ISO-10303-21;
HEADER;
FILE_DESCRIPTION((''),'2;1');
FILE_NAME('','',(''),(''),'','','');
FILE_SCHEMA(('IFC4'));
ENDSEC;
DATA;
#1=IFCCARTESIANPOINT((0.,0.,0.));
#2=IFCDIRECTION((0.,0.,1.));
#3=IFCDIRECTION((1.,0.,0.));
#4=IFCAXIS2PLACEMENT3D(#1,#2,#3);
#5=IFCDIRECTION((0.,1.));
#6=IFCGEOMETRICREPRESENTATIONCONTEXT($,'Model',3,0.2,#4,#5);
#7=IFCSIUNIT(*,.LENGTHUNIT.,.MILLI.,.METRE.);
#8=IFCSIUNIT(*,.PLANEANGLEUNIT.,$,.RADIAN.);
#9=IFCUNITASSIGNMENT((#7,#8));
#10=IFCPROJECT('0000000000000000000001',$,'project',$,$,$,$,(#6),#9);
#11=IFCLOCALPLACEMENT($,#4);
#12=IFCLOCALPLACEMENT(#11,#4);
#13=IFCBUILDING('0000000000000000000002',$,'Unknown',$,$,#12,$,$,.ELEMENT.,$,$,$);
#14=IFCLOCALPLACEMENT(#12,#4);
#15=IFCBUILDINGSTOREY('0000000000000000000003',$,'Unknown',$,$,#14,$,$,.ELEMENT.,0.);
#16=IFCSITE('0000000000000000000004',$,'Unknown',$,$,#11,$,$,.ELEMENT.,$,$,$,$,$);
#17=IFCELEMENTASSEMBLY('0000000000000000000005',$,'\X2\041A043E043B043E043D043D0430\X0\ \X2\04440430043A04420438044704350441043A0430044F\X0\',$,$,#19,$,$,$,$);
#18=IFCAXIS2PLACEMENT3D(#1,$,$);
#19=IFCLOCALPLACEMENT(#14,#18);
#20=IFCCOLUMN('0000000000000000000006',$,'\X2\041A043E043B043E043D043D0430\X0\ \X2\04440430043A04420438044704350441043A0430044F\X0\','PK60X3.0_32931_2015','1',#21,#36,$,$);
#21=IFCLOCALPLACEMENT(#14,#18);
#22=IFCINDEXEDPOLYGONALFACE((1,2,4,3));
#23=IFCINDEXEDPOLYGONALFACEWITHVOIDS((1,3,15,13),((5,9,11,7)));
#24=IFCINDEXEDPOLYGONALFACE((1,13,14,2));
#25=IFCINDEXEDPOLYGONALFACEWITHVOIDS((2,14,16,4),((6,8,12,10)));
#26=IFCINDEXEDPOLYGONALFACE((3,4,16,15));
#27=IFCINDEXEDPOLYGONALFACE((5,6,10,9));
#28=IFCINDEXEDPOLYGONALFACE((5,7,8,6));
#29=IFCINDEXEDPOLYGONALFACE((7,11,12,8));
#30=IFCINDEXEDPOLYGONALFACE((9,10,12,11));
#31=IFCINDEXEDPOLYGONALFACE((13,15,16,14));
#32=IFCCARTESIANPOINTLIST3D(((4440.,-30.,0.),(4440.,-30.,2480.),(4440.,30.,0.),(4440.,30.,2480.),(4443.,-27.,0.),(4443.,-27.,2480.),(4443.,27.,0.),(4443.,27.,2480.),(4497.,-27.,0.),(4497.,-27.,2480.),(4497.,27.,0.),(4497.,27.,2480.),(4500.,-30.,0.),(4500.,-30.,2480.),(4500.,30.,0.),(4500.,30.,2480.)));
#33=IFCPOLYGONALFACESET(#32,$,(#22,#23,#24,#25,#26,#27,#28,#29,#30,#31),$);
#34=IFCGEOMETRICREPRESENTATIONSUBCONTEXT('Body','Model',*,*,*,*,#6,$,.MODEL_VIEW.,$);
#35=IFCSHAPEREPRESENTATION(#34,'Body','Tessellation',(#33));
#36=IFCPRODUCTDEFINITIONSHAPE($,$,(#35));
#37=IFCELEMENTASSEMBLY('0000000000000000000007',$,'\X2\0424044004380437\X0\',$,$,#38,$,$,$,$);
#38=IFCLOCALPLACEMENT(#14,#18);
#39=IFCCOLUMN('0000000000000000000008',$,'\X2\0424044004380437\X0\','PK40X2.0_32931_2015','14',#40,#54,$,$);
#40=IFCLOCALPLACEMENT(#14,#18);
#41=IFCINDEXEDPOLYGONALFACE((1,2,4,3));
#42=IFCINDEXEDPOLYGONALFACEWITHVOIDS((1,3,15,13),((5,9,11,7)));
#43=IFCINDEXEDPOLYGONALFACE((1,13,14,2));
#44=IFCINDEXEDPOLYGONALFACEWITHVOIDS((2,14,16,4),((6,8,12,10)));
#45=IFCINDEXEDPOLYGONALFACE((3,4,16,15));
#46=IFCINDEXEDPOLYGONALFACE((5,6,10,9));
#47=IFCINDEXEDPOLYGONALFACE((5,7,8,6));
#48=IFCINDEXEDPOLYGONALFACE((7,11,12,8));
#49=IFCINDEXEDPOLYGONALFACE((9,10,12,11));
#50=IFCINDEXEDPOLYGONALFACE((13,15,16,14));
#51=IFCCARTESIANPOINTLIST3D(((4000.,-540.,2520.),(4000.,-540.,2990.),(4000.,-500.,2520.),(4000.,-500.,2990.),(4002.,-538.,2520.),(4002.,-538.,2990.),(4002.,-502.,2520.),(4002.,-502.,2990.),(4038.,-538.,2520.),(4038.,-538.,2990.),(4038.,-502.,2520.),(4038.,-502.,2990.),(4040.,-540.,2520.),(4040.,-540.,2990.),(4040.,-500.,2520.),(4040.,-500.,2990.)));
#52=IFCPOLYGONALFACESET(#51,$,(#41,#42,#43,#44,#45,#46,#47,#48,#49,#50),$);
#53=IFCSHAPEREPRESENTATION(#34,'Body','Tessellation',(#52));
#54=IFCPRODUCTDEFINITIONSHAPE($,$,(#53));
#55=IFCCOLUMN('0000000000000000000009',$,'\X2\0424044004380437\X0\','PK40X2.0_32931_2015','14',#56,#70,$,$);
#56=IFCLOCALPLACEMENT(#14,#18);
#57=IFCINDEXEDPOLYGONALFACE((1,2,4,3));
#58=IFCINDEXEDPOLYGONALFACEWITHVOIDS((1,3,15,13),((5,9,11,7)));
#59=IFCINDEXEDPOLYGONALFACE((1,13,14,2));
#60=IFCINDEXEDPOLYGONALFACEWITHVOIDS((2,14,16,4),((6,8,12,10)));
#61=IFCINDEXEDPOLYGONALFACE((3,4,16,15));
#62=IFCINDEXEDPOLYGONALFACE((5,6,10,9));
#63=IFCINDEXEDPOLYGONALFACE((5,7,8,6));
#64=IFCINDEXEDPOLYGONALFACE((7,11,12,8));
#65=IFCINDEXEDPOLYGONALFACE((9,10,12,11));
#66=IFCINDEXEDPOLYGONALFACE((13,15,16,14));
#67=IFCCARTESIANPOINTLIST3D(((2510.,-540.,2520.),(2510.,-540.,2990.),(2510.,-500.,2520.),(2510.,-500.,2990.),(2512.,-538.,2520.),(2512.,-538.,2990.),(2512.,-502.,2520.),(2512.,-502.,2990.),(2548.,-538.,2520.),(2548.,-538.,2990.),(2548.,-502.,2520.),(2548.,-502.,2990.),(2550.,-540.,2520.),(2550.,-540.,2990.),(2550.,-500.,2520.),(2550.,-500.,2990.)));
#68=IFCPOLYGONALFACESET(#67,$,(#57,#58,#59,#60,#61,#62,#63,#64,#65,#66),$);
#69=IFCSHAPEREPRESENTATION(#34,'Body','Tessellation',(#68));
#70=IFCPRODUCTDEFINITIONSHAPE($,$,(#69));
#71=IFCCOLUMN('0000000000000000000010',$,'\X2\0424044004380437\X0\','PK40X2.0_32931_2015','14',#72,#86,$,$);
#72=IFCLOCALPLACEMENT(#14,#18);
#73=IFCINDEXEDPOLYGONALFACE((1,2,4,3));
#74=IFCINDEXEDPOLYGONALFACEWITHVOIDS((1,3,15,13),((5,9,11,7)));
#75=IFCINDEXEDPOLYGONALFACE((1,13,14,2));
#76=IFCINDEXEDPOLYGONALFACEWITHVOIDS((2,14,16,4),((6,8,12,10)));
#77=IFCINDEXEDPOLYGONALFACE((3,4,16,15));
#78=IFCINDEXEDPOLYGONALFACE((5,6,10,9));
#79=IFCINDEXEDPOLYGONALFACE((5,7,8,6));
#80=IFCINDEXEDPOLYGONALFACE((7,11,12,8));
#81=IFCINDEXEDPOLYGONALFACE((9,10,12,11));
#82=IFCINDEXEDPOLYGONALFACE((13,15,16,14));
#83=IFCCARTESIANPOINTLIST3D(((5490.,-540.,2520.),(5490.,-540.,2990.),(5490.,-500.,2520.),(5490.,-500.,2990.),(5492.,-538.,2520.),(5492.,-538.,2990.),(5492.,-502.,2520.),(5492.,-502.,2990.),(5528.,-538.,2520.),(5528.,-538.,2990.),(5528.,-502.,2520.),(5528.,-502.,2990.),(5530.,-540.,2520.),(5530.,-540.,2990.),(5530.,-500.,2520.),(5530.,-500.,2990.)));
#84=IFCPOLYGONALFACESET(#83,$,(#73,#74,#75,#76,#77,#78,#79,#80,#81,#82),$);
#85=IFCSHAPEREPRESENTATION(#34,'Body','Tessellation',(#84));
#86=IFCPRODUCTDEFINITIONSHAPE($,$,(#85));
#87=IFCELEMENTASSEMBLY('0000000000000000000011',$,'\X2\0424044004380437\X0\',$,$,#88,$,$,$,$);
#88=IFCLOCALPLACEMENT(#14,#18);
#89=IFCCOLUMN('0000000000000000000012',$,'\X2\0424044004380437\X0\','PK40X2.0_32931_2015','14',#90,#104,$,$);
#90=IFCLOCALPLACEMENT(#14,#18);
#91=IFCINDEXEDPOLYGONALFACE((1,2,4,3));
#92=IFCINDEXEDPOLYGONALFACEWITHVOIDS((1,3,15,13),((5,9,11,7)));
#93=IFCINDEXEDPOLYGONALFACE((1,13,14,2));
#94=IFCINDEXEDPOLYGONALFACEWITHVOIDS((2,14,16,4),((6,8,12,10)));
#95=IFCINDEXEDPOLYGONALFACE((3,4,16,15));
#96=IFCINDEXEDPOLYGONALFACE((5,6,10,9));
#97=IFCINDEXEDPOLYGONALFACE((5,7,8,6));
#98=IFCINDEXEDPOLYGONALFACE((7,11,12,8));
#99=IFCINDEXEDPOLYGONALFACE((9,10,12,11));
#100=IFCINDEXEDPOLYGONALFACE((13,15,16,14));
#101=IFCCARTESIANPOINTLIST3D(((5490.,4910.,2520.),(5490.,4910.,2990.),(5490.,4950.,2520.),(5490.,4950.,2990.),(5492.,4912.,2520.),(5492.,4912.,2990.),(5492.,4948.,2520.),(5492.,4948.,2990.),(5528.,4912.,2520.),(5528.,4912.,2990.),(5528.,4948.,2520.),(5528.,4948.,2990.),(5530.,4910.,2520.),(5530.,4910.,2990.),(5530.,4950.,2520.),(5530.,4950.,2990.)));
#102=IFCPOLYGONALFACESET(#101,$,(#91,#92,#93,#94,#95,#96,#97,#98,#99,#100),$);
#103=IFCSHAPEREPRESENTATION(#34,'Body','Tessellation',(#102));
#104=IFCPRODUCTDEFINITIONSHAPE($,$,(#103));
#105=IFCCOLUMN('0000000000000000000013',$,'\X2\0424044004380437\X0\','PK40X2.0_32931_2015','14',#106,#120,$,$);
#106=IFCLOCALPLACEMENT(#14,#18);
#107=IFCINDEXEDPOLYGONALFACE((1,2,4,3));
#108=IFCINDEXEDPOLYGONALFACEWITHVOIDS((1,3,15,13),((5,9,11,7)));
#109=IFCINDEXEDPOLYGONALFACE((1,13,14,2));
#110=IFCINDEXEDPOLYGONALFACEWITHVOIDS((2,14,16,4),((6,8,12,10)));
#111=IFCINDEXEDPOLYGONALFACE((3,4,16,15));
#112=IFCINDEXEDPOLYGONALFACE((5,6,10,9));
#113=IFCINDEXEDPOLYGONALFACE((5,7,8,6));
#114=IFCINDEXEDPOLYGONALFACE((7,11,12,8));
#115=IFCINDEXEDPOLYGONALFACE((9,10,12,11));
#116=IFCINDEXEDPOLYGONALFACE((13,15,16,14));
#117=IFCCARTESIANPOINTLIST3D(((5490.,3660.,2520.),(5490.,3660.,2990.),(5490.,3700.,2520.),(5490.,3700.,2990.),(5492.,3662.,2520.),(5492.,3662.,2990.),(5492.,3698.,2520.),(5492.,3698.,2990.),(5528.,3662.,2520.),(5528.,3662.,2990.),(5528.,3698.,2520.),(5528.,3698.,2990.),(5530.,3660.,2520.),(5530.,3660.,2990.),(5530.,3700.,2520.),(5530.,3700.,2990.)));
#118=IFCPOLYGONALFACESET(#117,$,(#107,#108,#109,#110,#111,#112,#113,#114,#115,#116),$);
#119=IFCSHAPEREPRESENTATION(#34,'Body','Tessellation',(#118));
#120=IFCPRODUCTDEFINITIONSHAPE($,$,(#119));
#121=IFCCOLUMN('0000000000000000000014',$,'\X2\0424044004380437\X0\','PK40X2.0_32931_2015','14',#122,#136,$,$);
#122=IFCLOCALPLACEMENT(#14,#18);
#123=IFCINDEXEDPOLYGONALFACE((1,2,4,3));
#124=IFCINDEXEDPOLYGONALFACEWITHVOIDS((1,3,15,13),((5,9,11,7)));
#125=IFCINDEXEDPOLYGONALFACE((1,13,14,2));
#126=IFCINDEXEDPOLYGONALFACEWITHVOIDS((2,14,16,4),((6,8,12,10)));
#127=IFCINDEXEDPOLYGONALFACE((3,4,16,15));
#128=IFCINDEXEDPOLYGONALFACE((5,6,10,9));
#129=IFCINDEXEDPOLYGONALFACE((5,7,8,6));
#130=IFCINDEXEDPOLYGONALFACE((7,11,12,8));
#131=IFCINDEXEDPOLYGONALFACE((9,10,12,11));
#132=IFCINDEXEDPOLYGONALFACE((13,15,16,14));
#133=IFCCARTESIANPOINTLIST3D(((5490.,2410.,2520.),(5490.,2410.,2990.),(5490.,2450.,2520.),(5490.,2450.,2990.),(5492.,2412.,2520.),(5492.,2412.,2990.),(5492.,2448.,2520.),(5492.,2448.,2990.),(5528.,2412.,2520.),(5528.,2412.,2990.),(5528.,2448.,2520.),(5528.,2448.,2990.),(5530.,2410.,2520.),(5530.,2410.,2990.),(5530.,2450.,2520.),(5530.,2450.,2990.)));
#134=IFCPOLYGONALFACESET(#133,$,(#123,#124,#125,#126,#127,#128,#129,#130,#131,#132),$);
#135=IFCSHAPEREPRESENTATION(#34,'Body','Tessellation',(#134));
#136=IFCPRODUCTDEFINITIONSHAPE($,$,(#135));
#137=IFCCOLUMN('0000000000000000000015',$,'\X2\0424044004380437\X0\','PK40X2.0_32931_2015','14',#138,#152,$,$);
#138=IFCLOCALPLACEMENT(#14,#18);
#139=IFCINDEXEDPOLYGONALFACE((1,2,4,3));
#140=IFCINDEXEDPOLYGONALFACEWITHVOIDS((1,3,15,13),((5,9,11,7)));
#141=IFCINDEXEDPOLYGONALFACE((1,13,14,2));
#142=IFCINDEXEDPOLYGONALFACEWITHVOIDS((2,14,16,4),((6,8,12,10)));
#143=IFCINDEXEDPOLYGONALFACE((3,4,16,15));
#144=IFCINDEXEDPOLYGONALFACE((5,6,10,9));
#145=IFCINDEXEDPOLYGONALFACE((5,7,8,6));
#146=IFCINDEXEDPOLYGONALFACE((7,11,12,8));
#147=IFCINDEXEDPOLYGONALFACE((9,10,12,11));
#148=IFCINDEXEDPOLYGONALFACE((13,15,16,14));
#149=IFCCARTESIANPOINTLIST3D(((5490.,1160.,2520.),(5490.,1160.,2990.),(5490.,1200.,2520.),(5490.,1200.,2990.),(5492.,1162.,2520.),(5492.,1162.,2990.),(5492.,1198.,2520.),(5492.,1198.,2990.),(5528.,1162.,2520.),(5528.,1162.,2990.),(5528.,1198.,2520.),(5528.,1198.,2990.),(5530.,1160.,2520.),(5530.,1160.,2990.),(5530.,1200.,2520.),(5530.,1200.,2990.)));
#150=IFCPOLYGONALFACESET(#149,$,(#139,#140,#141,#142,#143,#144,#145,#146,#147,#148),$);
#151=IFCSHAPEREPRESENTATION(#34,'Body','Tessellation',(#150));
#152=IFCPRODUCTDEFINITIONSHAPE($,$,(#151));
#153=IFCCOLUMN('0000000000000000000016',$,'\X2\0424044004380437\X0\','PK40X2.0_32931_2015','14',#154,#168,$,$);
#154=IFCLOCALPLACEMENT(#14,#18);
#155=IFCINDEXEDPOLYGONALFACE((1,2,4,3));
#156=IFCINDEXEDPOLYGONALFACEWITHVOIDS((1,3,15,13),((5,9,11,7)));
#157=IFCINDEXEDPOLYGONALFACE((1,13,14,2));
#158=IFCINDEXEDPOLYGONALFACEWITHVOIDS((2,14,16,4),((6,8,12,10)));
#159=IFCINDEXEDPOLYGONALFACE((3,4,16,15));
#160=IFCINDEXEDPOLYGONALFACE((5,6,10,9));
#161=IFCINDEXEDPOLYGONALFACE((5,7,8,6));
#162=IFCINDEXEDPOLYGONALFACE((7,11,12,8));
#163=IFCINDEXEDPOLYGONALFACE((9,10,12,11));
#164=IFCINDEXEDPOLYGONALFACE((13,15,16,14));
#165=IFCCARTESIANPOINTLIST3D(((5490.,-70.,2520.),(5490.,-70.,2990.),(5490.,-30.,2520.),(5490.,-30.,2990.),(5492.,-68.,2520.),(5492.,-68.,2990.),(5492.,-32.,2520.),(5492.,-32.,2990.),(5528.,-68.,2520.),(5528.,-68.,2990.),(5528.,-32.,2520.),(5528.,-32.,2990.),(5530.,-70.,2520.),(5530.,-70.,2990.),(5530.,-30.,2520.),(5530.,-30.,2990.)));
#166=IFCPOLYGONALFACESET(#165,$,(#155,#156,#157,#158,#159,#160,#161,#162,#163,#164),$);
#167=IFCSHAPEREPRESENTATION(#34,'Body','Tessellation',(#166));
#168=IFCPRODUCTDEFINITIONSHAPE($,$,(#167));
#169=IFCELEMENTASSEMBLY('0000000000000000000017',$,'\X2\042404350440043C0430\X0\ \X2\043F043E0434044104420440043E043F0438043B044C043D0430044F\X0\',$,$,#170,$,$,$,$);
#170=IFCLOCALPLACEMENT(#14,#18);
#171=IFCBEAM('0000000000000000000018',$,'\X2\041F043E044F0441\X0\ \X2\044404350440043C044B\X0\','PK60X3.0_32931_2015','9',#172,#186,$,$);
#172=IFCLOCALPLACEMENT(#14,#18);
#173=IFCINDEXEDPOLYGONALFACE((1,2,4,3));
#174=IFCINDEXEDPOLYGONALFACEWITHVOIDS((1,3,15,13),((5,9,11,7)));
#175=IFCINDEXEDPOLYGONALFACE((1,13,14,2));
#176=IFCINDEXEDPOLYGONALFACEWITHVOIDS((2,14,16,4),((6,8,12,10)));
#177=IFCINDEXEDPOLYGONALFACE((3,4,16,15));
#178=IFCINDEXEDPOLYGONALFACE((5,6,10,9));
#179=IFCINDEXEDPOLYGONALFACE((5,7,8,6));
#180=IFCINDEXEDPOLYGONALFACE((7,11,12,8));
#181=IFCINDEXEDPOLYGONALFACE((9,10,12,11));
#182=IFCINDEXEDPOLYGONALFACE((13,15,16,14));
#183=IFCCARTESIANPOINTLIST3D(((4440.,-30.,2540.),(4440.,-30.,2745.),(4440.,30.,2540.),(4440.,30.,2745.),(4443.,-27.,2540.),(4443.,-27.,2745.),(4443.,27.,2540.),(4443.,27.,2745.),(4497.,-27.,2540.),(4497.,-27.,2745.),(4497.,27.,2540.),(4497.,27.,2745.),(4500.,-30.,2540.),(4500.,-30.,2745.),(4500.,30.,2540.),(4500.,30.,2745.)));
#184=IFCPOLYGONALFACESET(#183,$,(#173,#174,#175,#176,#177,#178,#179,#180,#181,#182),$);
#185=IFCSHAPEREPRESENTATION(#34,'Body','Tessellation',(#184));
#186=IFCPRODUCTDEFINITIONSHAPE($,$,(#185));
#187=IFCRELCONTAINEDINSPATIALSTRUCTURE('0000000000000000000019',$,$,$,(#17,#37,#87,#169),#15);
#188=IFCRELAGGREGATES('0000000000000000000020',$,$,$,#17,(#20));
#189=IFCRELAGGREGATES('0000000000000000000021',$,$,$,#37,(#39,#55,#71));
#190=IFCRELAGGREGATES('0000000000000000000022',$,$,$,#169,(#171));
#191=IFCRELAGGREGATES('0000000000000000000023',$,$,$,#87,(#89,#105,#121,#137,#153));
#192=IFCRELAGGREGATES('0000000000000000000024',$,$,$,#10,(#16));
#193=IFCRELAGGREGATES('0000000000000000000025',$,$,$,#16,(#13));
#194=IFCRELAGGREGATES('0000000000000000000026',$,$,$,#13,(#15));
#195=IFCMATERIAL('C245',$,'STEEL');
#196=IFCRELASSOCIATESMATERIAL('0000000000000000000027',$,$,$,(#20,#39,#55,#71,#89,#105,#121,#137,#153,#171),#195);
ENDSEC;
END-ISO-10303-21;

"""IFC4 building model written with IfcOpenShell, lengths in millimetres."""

from ifc_helpers import new_model, si_unit, direction, frame, origin_with_axes, place, context, subcontext, project, spatial, line, indexed_curve, outline, extrude, material, element, aggregate, save


model = new_model("IFC4")

# Units and contexts
model_context = context("Model", 3, precision=0.2, world=origin_with_axes(), true_north=direction((0.0, 1.0)))
body_context = subcontext(model_context, "Body", "Model", "MODEL_VIEW")
ifc_project = project(units=[si_unit("LENGTHUNIT", "METRE", prefix="MILLI"), si_unit("PLANEANGLEUNIT", "RADIAN")], contexts=[model_context])

# Site, building, storey
site_placement = place(None, origin_with_axes())
site = spatial("IfcSite", under=ifc_project, at=site_placement, Name="Unknown", CompositionType="ELEMENT")
building_placement = place(site_placement, origin_with_axes())
building = spatial("IfcBuilding", under=site, at=building_placement, Name="Unknown", CompositionType="ELEMENT")
storey_placement = place(building_placement, origin_with_axes())
storey = spatial("IfcBuildingStorey", under=building, at=storey_placement, Name="Unknown", CompositionType="ELEMENT", Elevation=0.0)

# Element assembly, column
assembly_1_placement = place(storey_placement, frame((4470.0, 0.0, 0.0), z_axis=(-1.0, 0.0, 0.0), x_axis=(0.0, 0.0, 1.0)))
assembly_1 = element("IfcElementAssembly", 1, at=assembly_1_placement, inside=storey, Name="Колонна фактическая")
ifc_material = material(Name="C245", Category="STEEL")
column_1_placement = place(assembly_1_placement, origin_with_axes())
column_1 = element("IfcColumn", 2, at=column_1_placement, material=ifc_material, Name="Колонна фактическая", Description="PK60X3.0_32931_2015", ObjectType="1", context=body_context, shape_type="SolidModel", body=[
    extrude(outline(indexed_curve([(-30.0, -30.0), (30.0, -30.0), (30.0, 30.0), (-30.0, 30.0)], segments=[line(1, 2, 3, 4, 1)]), holes=[indexed_curve([(-27.0, -27.0), (-27.0, 27.0), (27.0, 27.0), (27.0, -27.0)], segments=[line(1, 2, 3, 4, 1)])]), frame((0.0, 0.0, 0.0), z_axis=(-1.0, 0.0, 0.0), x_axis=(0.0, 0.0, 1.0)), (0.0, 0.0, -1.0), 2480.0),
])
aggregate(assembly_1, [column_1])

# Element assemblies, columns
assembly_2_placement = place(storey_placement, frame((-470.0, -520.0, 3010.0), z_axis=(0.0, -1.0, 0.0), x_axis=(1.0, 0.0, 0.0)))
assembly_2 = element("IfcElementAssembly", 3, at=assembly_2_placement, inside=storey, Name="Фриз")
column_2_placement = place(assembly_2_placement, frame((4490.0, -490.0, 0.0), z_axis=(0.0, 0.0, -1.0), x_axis=(0.0, 1.0, 0.0)))
column_2 = element("IfcColumn", 4, at=column_2_placement, material=ifc_material, Name="Фриз", Description="PK40X2.0_32931_2015", ObjectType="14", context=body_context, shape_type="SolidModel", body=[
    extrude(outline(indexed_curve([(-20.0, -20.0), (20.0, -20.0), (20.0, 20.0), (-20.0, 20.0)], segments=[line(1, 2, 3, 4, 1)]), holes=[indexed_curve([(-18.0, -18.0), (-18.0, 18.0), (18.0, 18.0), (18.0, -18.0)], segments=[line(1, 2, 3, 4, 1)])]), frame((0.0, 0.0, 0.0), z_axis=(-1.0, 0.0, 0.0), x_axis=(0.0, 0.0, 1.0)), (0.0, 0.0, -1.0), 470.0),
])
column_3_placement = place(assembly_2_placement, frame((3000.0, -490.0, 0.0), z_axis=(0.0, 0.0, -1.0), x_axis=(0.0, 1.0, 0.0)))
column_3 = element("IfcColumn", 5, at=column_3_placement, material=ifc_material, Name="Фриз", Description="PK40X2.0_32931_2015", ObjectType="14", context=body_context, shape_type="SolidModel", body=[
    extrude(outline(indexed_curve([(-20.0, -20.0), (20.0, -20.0), (20.0, 20.0), (-20.0, 20.0)], segments=[line(1, 2, 3, 4, 1)]), holes=[indexed_curve([(-18.0, -18.0), (-18.0, 18.0), (18.0, 18.0), (18.0, -18.0)], segments=[line(1, 2, 3, 4, 1)])]), frame((0.0, 0.0, 0.0), z_axis=(-1.0, 0.0, 0.0), x_axis=(0.0, 0.0, 1.0)), (0.0, 0.0, -1.0), 470.0),
])
column_4_placement = place(assembly_2_placement, frame((5980.0, -490.0, 0.0), z_axis=(0.0, 0.0, 1.0), x_axis=(0.0, 1.0, 0.0)))
column_4 = element("IfcColumn", 6, at=column_4_placement, material=ifc_material, Name="Фриз", Description="PK40X2.0_32931_2015", ObjectType="14", context=body_context, shape_type="SolidModel", body=[
    extrude(outline(indexed_curve([(-20.0, -20.0), (20.0, -20.0), (20.0, 20.0), (-20.0, 20.0)], segments=[line(1, 2, 3, 4, 1)]), holes=[indexed_curve([(-18.0, -18.0), (-18.0, 18.0), (18.0, 18.0), (18.0, -18.0)], segments=[line(1, 2, 3, 4, 1)])]), frame((0.0, 0.0, 0.0), z_axis=(-1.0, 0.0, 0.0), x_axis=(0.0, 0.0, 1.0)), (0.0, 0.0, -1.0), 470.0),
])
aggregate(assembly_2, [column_2, column_3, column_4])
assembly_3_placement = place(storey_placement, frame((5510.0, -500.0, 3010.0), z_axis=(1.0, 0.0, 0.0), x_axis=(0.0, 1.0, 0.0)))
assembly_3 = element("IfcElementAssembly", 7, at=assembly_3_placement, inside=storey, Name="Фриз")
column_5_placement = place(assembly_3_placement, frame((5430.0, -490.0, 0.0), z_axis=(-1.0, 0.0, 0.0), x_axis=(0.0, 1.0, 0.0)))
column_5 = element("IfcColumn", 8, at=column_5_placement, material=ifc_material, Name="Фриз", Description="PK40X2.0_32931_2015", ObjectType="14", context=body_context, shape_type="SolidModel", body=[
    extrude(outline(indexed_curve([(-20.0, -20.0), (20.0, -20.0), (20.0, 20.0), (-20.0, 20.0)], segments=[line(1, 2, 3, 4, 1)]), holes=[indexed_curve([(-18.0, -18.0), (-18.0, 18.0), (18.0, 18.0), (18.0, -18.0)], segments=[line(1, 2, 3, 4, 1)])]), frame((0.0, 0.0, 0.0), z_axis=(-1.0, 0.0, 0.0), x_axis=(0.0, 0.0, 1.0)), (0.0, 0.0, -1.0), 470.0),
])
column_6_placement = place(assembly_3_placement, frame((4180.0, -490.0, 0.0), z_axis=(-1.0, 0.0, 0.0), x_axis=(0.0, 1.0, 0.0)))
column_6 = element("IfcColumn", 9, at=column_6_placement, material=ifc_material, Name="Фриз", Description="PK40X2.0_32931_2015", ObjectType="14", context=body_context, shape_type="SolidModel", body=[
    extrude(outline(indexed_curve([(-20.0, -20.0), (20.0, -20.0), (20.0, 20.0), (-20.0, 20.0)], segments=[line(1, 2, 3, 4, 1)]), holes=[indexed_curve([(-18.0, -18.0), (-18.0, 18.0), (18.0, 18.0), (18.0, -18.0)], segments=[line(1, 2, 3, 4, 1)])]), frame((0.0, 0.0, 0.0), z_axis=(-1.0, 0.0, 0.0), x_axis=(0.0, 0.0, 1.0)), (0.0, 0.0, -1.0), 470.0),
])
column_7_placement = place(assembly_3_placement, frame((2930.0, -490.0, 0.0), z_axis=(-1.0, 0.0, 0.0), x_axis=(0.0, 1.0, 0.0)))
column_7 = element("IfcColumn", 10, at=column_7_placement, material=ifc_material, Name="Фриз", Description="PK40X2.0_32931_2015", ObjectType="14", context=body_context, shape_type="SolidModel", body=[
    extrude(outline(indexed_curve([(-20.0, -20.0), (20.0, -20.0), (20.0, 20.0), (-20.0, 20.0)], segments=[line(1, 2, 3, 4, 1)]), holes=[indexed_curve([(-18.0, -18.0), (-18.0, 18.0), (18.0, 18.0), (18.0, -18.0)], segments=[line(1, 2, 3, 4, 1)])]), frame((0.0, 0.0, 0.0), z_axis=(-1.0, 0.0, 0.0), x_axis=(0.0, 0.0, 1.0)), (0.0, 0.0, -1.0), 470.0),
])
column_8_placement = place(assembly_3_placement, frame((1680.0, -490.0, 0.0), z_axis=(-1.0, 0.0, 0.0), x_axis=(0.0, 1.0, 0.0)))
column_8 = element("IfcColumn", 11, at=column_8_placement, material=ifc_material, Name="Фриз", Description="PK40X2.0_32931_2015", ObjectType="14", context=body_context, shape_type="SolidModel", body=[
    extrude(outline(indexed_curve([(-20.0, -20.0), (20.0, -20.0), (20.0, 20.0), (-20.0, 20.0)], segments=[line(1, 2, 3, 4, 1)]), holes=[indexed_curve([(-18.0, -18.0), (-18.0, 18.0), (18.0, 18.0), (18.0, -18.0)], segments=[line(1, 2, 3, 4, 1)])]), frame((0.0, 0.0, 0.0), z_axis=(-1.0, 0.0, 0.0), x_axis=(0.0, 0.0, 1.0)), (0.0, 0.0, -1.0), 470.0),
])
column_9_placement = place(assembly_3_placement, frame((450.0, -490.0, 0.0), z_axis=(-1.0, 0.0, 0.0), x_axis=(0.0, 1.0, 0.0)))
column_9 = element("IfcColumn", 12, at=column_9_placement, material=ifc_material, Name="Фриз", Description="PK40X2.0_32931_2015", ObjectType="14", context=body_context, shape_type="SolidModel", body=[
    extrude(outline(indexed_curve([(-20.0, -20.0), (20.0, -20.0), (20.0, 20.0), (-20.0, 20.0)], segments=[line(1, 2, 3, 4, 1)]), holes=[indexed_curve([(-18.0, -18.0), (-18.0, 18.0), (18.0, 18.0), (18.0, -18.0)], segments=[line(1, 2, 3, 4, 1)])]), frame((0.0, 0.0, 0.0), z_axis=(-1.0, 0.0, 0.0), x_axis=(0.0, 0.0, 1.0)), (0.0, 0.0, -1.0), 470.0),
])

# Element assembly, beam
assembly_4_placement = place(storey_placement, frame((4470.0, 4940.0, 2775.0), z_axis=(-1.0, 0.0, 0.0), x_axis=(0.0, -1.0, 0.0)))
assembly_4 = element("IfcElementAssembly", 13, at=assembly_4_placement, inside=storey, Name="Ферма подстропильная")
beam_1_placement = place(assembly_4_placement, frame((4940.0, -30.0, 0.0), z_axis=(1.0, 0.0, 0.0), x_axis=(0.0, -1.0, 0.0)))
beam_1 = element("IfcBeam", 14, at=beam_1_placement, material=ifc_material, Name="Пояс фермы", Description="PK60X3.0_32931_2015", ObjectType="9", context=body_context, shape_type="SolidModel", body=[
    extrude(outline(indexed_curve([(-30.0, -30.0), (30.0, -30.0), (30.0, 30.0), (-30.0, 30.0)], segments=[line(1, 2, 3, 4, 1)]), holes=[indexed_curve([(-27.0, -27.0), (-27.0, 27.0), (27.0, 27.0), (27.0, -27.0)], segments=[line(1, 2, 3, 4, 1)])]), frame((0.0, 0.0, 0.0), z_axis=(-1.0, 0.0, 0.0), x_axis=(0.0, 0.0, 1.0)), (0.0, 0.0, -1.0), 205.0),
])
aggregate(assembly_4, [beam_1])

aggregate(assembly_3, [column_5, column_6, column_7, column_8, column_9])

save(model, "model.ifc")
